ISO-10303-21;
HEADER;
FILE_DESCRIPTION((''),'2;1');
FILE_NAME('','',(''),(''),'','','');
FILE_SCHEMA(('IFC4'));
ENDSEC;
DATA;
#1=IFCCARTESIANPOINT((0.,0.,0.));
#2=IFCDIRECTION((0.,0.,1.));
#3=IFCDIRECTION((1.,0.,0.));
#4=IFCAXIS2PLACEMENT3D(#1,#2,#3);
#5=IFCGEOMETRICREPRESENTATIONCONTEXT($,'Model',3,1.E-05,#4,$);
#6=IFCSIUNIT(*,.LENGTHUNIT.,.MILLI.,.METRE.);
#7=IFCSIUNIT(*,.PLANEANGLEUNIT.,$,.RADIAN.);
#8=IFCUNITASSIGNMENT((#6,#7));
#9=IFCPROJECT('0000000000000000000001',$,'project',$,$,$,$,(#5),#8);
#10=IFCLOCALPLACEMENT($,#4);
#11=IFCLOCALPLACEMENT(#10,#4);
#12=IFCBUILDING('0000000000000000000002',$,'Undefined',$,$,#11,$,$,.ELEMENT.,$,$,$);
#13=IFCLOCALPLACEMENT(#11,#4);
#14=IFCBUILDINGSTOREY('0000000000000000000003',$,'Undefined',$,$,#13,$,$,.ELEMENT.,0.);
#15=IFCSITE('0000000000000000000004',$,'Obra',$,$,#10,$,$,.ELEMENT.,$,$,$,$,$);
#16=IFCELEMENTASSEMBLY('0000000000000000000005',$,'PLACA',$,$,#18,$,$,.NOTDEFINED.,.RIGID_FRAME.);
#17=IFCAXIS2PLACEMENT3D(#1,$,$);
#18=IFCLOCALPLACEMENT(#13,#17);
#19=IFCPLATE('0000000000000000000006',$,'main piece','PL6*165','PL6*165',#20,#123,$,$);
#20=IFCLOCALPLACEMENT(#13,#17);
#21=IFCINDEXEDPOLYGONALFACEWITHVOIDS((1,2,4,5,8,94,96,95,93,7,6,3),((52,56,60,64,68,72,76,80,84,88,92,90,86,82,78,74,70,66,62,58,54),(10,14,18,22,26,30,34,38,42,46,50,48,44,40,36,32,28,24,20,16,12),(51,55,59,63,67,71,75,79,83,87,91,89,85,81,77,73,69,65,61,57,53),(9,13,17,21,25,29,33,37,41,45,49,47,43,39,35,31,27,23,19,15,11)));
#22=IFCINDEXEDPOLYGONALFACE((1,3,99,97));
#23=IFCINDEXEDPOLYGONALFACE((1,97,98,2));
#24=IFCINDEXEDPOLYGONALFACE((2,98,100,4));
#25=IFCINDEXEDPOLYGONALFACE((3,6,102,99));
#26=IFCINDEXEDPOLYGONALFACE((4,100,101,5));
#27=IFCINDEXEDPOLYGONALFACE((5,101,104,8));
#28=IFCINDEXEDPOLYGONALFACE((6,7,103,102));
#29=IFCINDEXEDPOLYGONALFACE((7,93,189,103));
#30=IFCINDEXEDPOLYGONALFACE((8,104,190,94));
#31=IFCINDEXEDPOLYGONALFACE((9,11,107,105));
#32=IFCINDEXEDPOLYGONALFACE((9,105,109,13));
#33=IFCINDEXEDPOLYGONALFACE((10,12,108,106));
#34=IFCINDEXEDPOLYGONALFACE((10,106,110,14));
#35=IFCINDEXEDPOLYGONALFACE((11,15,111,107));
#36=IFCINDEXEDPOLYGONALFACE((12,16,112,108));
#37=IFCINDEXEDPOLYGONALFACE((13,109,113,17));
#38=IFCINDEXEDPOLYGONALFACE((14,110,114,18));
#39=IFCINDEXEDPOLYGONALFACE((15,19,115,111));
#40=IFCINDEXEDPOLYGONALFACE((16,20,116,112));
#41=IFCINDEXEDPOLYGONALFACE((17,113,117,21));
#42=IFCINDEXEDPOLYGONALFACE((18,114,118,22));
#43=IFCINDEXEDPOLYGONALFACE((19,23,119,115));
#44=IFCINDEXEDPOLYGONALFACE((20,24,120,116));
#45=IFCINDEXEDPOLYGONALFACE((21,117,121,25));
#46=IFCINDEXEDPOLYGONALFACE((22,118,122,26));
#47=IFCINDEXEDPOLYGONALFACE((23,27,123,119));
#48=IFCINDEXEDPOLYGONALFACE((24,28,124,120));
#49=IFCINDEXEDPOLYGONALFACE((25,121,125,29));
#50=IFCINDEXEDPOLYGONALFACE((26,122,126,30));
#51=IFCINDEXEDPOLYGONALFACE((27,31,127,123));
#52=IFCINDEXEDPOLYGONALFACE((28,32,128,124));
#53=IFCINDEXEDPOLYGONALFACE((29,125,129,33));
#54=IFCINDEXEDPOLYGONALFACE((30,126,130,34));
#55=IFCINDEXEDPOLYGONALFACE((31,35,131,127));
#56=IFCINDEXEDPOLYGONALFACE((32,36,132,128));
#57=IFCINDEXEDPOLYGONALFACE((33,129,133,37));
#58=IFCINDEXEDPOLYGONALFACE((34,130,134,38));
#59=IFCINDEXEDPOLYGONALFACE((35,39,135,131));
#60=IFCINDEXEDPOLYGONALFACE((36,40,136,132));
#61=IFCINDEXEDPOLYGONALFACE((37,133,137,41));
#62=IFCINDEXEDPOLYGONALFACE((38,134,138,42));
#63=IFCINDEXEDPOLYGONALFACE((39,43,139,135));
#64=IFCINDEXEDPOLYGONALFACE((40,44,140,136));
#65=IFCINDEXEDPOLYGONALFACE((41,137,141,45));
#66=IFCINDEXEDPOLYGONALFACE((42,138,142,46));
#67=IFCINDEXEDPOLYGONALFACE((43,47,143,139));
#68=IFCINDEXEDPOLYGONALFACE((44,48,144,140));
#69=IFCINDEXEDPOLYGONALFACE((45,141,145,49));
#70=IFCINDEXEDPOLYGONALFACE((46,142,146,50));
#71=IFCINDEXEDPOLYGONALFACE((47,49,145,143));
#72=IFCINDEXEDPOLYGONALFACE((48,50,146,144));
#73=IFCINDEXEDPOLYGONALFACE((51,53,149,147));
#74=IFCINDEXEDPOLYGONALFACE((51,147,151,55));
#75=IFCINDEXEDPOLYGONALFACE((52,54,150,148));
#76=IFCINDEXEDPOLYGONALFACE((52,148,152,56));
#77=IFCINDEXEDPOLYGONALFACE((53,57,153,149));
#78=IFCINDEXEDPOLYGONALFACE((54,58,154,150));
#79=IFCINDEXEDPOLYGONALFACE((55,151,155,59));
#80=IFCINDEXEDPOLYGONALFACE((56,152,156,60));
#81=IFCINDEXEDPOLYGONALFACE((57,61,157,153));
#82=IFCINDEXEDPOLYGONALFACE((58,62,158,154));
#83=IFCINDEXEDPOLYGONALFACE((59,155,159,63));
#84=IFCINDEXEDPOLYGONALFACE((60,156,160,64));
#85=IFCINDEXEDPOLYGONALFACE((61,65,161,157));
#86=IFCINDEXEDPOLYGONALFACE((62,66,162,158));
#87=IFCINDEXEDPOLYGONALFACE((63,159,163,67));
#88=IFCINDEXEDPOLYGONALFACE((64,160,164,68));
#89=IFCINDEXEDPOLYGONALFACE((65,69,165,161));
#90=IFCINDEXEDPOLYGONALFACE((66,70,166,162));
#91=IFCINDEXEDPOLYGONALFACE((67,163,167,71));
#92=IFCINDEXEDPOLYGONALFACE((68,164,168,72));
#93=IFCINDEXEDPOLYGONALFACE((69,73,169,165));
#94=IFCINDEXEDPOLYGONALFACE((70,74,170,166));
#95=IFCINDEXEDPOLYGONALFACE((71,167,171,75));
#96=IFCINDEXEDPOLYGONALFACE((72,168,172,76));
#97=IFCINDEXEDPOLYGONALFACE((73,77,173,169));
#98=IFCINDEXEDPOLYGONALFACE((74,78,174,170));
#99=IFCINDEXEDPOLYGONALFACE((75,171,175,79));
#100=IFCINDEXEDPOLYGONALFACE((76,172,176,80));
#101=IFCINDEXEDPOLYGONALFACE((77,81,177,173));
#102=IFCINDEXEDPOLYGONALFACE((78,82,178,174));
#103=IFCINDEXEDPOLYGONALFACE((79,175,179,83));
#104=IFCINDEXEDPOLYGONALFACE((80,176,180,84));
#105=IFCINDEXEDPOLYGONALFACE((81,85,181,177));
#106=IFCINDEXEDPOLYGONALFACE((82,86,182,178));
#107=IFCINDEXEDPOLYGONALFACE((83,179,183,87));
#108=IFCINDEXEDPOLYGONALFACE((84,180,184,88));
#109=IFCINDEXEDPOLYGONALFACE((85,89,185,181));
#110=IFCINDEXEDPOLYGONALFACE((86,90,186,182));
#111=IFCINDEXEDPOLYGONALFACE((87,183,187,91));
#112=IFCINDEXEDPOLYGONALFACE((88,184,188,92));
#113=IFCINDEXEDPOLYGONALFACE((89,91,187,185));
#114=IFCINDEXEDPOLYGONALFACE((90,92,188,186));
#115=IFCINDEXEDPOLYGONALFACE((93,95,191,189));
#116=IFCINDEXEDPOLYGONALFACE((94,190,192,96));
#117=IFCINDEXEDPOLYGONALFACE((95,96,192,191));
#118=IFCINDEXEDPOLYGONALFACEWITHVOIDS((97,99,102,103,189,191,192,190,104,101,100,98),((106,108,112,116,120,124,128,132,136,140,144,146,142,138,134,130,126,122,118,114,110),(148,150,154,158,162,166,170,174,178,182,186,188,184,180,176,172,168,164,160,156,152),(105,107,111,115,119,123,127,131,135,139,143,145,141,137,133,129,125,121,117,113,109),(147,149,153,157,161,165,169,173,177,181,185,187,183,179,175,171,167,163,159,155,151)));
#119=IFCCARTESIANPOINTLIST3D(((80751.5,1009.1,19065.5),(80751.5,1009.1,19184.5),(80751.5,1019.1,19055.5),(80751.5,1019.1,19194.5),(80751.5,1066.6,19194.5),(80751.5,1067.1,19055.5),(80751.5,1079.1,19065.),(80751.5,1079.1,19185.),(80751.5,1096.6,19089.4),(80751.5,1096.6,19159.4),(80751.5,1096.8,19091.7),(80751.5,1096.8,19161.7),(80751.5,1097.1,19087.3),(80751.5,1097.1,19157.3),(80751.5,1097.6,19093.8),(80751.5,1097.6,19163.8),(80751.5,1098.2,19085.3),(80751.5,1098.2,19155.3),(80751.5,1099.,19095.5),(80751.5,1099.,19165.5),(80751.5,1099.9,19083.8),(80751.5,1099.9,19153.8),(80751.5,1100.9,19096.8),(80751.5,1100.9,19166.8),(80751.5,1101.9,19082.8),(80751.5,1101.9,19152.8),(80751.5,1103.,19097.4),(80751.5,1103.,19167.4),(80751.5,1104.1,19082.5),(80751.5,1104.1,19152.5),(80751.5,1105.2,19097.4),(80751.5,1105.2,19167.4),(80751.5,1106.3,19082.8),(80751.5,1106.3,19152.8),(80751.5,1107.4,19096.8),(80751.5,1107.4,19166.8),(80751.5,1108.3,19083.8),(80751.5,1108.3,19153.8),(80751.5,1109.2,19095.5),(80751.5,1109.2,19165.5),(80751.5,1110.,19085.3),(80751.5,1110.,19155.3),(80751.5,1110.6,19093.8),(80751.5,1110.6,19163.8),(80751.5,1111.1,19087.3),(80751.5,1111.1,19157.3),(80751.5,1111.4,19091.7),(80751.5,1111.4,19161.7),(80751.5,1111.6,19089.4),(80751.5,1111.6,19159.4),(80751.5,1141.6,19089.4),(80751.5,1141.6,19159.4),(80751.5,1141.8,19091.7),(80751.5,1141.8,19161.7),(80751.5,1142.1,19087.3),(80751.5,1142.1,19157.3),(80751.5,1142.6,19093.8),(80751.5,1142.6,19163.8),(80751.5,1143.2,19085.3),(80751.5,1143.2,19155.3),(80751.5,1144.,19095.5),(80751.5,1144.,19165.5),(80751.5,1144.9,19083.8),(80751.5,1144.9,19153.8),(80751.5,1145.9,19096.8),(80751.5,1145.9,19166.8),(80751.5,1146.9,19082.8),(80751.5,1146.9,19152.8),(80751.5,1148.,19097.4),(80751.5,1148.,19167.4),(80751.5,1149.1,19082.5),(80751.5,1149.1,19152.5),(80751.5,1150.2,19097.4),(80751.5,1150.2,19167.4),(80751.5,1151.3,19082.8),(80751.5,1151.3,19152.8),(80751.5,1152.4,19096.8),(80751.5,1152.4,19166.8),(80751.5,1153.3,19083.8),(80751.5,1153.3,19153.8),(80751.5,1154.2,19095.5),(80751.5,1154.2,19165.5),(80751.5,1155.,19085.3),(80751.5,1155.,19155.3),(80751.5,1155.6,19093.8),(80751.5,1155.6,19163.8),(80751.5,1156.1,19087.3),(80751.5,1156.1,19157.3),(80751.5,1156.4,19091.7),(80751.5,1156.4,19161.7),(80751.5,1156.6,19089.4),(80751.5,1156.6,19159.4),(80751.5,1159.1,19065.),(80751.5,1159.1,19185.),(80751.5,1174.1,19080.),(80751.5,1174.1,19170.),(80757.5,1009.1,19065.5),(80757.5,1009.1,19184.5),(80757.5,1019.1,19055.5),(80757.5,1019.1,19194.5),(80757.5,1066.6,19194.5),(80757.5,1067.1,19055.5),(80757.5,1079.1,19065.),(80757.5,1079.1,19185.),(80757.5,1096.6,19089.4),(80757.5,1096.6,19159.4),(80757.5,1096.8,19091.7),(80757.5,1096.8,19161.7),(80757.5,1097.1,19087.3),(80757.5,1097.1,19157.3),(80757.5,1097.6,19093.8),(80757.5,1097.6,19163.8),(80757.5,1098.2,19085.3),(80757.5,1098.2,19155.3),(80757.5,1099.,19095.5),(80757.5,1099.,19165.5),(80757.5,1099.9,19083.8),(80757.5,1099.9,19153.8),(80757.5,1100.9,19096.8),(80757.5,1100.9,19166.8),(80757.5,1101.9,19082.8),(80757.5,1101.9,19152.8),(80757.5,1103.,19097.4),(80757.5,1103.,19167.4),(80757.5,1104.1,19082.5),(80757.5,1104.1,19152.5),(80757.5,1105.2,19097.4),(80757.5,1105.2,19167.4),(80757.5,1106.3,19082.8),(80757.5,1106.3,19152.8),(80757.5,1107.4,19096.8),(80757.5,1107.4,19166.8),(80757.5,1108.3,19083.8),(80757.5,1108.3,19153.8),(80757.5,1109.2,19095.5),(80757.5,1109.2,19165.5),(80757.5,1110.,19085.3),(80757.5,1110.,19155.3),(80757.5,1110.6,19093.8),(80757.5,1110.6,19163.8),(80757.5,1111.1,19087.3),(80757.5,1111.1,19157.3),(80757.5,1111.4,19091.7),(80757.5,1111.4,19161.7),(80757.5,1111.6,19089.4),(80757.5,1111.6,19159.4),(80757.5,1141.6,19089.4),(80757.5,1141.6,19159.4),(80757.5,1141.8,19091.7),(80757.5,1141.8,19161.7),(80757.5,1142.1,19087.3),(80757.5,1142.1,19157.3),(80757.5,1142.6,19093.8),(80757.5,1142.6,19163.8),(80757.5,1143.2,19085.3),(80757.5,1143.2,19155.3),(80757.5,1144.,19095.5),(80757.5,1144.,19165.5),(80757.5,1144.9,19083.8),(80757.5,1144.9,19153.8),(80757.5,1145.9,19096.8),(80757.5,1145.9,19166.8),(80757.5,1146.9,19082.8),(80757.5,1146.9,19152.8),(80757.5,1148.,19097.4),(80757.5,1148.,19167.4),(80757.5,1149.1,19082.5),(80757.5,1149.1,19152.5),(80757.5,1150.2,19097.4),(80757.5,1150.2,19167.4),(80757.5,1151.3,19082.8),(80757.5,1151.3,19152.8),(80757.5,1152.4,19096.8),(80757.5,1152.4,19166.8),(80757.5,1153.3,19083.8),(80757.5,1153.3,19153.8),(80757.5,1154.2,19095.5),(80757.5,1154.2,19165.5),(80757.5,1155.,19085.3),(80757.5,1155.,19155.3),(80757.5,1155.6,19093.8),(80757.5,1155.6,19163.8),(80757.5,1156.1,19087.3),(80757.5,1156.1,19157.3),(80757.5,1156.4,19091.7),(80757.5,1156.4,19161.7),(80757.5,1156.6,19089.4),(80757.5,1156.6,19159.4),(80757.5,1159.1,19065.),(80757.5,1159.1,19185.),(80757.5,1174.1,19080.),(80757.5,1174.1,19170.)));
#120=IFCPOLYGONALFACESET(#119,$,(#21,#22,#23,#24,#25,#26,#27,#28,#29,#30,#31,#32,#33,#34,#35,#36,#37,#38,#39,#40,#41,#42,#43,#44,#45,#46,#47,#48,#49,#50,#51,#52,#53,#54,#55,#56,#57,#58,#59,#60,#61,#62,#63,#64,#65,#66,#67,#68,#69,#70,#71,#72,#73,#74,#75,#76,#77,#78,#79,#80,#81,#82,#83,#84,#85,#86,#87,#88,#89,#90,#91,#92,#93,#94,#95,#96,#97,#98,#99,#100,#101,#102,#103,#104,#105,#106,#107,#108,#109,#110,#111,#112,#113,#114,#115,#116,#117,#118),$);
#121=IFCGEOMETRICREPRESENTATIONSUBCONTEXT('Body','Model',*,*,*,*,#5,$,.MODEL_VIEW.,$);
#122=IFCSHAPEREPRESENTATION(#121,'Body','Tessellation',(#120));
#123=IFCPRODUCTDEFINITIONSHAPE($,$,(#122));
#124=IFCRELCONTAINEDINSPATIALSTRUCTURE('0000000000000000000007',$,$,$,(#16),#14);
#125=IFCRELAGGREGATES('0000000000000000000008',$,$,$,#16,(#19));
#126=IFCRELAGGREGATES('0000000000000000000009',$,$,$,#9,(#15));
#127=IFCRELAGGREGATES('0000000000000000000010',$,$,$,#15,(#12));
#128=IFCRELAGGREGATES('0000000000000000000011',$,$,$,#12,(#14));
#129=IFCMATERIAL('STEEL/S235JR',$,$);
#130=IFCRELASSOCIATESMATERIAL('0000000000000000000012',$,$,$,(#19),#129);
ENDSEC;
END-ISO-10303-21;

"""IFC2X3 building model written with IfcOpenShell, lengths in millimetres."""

from ifc_helpers import new_model, si_unit, frame, origin_with_axes, origin_2d_with_axis, place, context, subcontext, project, spatial, polyline, circle, outline, extrude, source, transform, mapped, material, element, aggregate, save


model = new_model("IFC2X3")

# Units and contexts
model_context = context("Model", 3, precision=1e-05, world=origin_with_axes())
body_context = subcontext(model_context, "Body", "Model", "MODEL_VIEW")
ifc_project = project(units=[si_unit("LENGTHUNIT", "METRE", prefix="MILLI"), si_unit("PLANEANGLEUNIT", "RADIAN")], contexts=[model_context])

# Site, building, storey
site_placement = place(None, origin_with_axes())
site = spatial("IfcSite", under=ifc_project, at=site_placement, Name="Obra", CompositionType="ELEMENT")
building_placement = place(site_placement, origin_with_axes())
building = spatial("IfcBuilding", under=site, at=building_placement, Name="Undefined", CompositionType="ELEMENT")
storey_placement = place(building_placement, origin_with_axes())
storey = spatial("IfcBuildingStorey", under=building, at=storey_placement, Name="Undefined", CompositionType="ELEMENT", Elevation=0.0)

# Shared definitions
ifc_material_1 = material(Name="STEEL/S235JR")

# Element assembly, plate, opening
shared_shape_1 = source(origin_with_axes(), body_context, "Body", "SweptSolid", [
    extrude(circle(Radius=7.5, at=origin_2d_with_axis()), frame((0.0, 2.4, 0.0), z_axis=(0.0, 1.0, 0.0), x_axis=(1.0, 0.0, 0.0)), (0.0, 0.0, 1.0), 6.2),
])
assembly_1_placement = place(storey_placement, origin_with_axes())
assembly_1 = element("IfcElementAssembly", 1, at=assembly_1_placement, inside=storey, Name="PLACA", AssemblyPlace="NOTDEFINED", PredefinedType="RIGID_FRAME")
plate_1_placement = place(assembly_1_placement, frame((80754.5, 1009.1, 19065.5), z_axis=(1.0, 0.0, 0.0), x_axis=(0.0, 0.707107, -0.707107)))
plate_1 = element("IfcPlate", 2, at=plate_1_placement, material=ifc_material_1, Name="main piece", Description="PL6*165", ObjectType="PL6*165", context=body_context, shape_type="SweptSolid", body=[
    extrude(outline(polyline([(0.0, 0.0), (14.1, 0.0), (48.1, 33.9), (49.9, 49.1), (106.4, 105.7), (106.4, 126.9), (42.8, 190.6), (21.6, 190.6), (-35.0, 134.0), (-50.6, 131.9), (-84.1, 98.3), (-84.1, 84.1), (0.0, 0.0)])), frame((0.0, 0.0, -3.0), z_axis=(0.0, 0.0, 1.0), x_axis=(1.0, 0.0, 0.0)), (0.0, 0.0, 1.0), 6.0),
])
opening_1_placement = place(assembly_1_placement, frame((80760.0, 1126.6, 19160.0), z_axis=(0.0, 1.0, 0.0), x_axis=(0.0, 0.0, -1.0)))
element("IfcOpeningElement", 3, at=opening_1_placement, cuts=plate_1, ObjectType="Opening", context=body_context, shape_type="MappedRepresentation", body=[
    mapped(shared_shape_1, transform((0.0, 0.0, -22.5))),
    mapped(shared_shape_1, transform((70.0, 0.0, -22.5))),
    mapped(shared_shape_1, transform((0.0, 0.0, 22.5))),
    mapped(shared_shape_1, transform((70.0, 0.0, 22.5))),
])
aggregate(assembly_1, [plate_1])

save(model, "model.ifc")
